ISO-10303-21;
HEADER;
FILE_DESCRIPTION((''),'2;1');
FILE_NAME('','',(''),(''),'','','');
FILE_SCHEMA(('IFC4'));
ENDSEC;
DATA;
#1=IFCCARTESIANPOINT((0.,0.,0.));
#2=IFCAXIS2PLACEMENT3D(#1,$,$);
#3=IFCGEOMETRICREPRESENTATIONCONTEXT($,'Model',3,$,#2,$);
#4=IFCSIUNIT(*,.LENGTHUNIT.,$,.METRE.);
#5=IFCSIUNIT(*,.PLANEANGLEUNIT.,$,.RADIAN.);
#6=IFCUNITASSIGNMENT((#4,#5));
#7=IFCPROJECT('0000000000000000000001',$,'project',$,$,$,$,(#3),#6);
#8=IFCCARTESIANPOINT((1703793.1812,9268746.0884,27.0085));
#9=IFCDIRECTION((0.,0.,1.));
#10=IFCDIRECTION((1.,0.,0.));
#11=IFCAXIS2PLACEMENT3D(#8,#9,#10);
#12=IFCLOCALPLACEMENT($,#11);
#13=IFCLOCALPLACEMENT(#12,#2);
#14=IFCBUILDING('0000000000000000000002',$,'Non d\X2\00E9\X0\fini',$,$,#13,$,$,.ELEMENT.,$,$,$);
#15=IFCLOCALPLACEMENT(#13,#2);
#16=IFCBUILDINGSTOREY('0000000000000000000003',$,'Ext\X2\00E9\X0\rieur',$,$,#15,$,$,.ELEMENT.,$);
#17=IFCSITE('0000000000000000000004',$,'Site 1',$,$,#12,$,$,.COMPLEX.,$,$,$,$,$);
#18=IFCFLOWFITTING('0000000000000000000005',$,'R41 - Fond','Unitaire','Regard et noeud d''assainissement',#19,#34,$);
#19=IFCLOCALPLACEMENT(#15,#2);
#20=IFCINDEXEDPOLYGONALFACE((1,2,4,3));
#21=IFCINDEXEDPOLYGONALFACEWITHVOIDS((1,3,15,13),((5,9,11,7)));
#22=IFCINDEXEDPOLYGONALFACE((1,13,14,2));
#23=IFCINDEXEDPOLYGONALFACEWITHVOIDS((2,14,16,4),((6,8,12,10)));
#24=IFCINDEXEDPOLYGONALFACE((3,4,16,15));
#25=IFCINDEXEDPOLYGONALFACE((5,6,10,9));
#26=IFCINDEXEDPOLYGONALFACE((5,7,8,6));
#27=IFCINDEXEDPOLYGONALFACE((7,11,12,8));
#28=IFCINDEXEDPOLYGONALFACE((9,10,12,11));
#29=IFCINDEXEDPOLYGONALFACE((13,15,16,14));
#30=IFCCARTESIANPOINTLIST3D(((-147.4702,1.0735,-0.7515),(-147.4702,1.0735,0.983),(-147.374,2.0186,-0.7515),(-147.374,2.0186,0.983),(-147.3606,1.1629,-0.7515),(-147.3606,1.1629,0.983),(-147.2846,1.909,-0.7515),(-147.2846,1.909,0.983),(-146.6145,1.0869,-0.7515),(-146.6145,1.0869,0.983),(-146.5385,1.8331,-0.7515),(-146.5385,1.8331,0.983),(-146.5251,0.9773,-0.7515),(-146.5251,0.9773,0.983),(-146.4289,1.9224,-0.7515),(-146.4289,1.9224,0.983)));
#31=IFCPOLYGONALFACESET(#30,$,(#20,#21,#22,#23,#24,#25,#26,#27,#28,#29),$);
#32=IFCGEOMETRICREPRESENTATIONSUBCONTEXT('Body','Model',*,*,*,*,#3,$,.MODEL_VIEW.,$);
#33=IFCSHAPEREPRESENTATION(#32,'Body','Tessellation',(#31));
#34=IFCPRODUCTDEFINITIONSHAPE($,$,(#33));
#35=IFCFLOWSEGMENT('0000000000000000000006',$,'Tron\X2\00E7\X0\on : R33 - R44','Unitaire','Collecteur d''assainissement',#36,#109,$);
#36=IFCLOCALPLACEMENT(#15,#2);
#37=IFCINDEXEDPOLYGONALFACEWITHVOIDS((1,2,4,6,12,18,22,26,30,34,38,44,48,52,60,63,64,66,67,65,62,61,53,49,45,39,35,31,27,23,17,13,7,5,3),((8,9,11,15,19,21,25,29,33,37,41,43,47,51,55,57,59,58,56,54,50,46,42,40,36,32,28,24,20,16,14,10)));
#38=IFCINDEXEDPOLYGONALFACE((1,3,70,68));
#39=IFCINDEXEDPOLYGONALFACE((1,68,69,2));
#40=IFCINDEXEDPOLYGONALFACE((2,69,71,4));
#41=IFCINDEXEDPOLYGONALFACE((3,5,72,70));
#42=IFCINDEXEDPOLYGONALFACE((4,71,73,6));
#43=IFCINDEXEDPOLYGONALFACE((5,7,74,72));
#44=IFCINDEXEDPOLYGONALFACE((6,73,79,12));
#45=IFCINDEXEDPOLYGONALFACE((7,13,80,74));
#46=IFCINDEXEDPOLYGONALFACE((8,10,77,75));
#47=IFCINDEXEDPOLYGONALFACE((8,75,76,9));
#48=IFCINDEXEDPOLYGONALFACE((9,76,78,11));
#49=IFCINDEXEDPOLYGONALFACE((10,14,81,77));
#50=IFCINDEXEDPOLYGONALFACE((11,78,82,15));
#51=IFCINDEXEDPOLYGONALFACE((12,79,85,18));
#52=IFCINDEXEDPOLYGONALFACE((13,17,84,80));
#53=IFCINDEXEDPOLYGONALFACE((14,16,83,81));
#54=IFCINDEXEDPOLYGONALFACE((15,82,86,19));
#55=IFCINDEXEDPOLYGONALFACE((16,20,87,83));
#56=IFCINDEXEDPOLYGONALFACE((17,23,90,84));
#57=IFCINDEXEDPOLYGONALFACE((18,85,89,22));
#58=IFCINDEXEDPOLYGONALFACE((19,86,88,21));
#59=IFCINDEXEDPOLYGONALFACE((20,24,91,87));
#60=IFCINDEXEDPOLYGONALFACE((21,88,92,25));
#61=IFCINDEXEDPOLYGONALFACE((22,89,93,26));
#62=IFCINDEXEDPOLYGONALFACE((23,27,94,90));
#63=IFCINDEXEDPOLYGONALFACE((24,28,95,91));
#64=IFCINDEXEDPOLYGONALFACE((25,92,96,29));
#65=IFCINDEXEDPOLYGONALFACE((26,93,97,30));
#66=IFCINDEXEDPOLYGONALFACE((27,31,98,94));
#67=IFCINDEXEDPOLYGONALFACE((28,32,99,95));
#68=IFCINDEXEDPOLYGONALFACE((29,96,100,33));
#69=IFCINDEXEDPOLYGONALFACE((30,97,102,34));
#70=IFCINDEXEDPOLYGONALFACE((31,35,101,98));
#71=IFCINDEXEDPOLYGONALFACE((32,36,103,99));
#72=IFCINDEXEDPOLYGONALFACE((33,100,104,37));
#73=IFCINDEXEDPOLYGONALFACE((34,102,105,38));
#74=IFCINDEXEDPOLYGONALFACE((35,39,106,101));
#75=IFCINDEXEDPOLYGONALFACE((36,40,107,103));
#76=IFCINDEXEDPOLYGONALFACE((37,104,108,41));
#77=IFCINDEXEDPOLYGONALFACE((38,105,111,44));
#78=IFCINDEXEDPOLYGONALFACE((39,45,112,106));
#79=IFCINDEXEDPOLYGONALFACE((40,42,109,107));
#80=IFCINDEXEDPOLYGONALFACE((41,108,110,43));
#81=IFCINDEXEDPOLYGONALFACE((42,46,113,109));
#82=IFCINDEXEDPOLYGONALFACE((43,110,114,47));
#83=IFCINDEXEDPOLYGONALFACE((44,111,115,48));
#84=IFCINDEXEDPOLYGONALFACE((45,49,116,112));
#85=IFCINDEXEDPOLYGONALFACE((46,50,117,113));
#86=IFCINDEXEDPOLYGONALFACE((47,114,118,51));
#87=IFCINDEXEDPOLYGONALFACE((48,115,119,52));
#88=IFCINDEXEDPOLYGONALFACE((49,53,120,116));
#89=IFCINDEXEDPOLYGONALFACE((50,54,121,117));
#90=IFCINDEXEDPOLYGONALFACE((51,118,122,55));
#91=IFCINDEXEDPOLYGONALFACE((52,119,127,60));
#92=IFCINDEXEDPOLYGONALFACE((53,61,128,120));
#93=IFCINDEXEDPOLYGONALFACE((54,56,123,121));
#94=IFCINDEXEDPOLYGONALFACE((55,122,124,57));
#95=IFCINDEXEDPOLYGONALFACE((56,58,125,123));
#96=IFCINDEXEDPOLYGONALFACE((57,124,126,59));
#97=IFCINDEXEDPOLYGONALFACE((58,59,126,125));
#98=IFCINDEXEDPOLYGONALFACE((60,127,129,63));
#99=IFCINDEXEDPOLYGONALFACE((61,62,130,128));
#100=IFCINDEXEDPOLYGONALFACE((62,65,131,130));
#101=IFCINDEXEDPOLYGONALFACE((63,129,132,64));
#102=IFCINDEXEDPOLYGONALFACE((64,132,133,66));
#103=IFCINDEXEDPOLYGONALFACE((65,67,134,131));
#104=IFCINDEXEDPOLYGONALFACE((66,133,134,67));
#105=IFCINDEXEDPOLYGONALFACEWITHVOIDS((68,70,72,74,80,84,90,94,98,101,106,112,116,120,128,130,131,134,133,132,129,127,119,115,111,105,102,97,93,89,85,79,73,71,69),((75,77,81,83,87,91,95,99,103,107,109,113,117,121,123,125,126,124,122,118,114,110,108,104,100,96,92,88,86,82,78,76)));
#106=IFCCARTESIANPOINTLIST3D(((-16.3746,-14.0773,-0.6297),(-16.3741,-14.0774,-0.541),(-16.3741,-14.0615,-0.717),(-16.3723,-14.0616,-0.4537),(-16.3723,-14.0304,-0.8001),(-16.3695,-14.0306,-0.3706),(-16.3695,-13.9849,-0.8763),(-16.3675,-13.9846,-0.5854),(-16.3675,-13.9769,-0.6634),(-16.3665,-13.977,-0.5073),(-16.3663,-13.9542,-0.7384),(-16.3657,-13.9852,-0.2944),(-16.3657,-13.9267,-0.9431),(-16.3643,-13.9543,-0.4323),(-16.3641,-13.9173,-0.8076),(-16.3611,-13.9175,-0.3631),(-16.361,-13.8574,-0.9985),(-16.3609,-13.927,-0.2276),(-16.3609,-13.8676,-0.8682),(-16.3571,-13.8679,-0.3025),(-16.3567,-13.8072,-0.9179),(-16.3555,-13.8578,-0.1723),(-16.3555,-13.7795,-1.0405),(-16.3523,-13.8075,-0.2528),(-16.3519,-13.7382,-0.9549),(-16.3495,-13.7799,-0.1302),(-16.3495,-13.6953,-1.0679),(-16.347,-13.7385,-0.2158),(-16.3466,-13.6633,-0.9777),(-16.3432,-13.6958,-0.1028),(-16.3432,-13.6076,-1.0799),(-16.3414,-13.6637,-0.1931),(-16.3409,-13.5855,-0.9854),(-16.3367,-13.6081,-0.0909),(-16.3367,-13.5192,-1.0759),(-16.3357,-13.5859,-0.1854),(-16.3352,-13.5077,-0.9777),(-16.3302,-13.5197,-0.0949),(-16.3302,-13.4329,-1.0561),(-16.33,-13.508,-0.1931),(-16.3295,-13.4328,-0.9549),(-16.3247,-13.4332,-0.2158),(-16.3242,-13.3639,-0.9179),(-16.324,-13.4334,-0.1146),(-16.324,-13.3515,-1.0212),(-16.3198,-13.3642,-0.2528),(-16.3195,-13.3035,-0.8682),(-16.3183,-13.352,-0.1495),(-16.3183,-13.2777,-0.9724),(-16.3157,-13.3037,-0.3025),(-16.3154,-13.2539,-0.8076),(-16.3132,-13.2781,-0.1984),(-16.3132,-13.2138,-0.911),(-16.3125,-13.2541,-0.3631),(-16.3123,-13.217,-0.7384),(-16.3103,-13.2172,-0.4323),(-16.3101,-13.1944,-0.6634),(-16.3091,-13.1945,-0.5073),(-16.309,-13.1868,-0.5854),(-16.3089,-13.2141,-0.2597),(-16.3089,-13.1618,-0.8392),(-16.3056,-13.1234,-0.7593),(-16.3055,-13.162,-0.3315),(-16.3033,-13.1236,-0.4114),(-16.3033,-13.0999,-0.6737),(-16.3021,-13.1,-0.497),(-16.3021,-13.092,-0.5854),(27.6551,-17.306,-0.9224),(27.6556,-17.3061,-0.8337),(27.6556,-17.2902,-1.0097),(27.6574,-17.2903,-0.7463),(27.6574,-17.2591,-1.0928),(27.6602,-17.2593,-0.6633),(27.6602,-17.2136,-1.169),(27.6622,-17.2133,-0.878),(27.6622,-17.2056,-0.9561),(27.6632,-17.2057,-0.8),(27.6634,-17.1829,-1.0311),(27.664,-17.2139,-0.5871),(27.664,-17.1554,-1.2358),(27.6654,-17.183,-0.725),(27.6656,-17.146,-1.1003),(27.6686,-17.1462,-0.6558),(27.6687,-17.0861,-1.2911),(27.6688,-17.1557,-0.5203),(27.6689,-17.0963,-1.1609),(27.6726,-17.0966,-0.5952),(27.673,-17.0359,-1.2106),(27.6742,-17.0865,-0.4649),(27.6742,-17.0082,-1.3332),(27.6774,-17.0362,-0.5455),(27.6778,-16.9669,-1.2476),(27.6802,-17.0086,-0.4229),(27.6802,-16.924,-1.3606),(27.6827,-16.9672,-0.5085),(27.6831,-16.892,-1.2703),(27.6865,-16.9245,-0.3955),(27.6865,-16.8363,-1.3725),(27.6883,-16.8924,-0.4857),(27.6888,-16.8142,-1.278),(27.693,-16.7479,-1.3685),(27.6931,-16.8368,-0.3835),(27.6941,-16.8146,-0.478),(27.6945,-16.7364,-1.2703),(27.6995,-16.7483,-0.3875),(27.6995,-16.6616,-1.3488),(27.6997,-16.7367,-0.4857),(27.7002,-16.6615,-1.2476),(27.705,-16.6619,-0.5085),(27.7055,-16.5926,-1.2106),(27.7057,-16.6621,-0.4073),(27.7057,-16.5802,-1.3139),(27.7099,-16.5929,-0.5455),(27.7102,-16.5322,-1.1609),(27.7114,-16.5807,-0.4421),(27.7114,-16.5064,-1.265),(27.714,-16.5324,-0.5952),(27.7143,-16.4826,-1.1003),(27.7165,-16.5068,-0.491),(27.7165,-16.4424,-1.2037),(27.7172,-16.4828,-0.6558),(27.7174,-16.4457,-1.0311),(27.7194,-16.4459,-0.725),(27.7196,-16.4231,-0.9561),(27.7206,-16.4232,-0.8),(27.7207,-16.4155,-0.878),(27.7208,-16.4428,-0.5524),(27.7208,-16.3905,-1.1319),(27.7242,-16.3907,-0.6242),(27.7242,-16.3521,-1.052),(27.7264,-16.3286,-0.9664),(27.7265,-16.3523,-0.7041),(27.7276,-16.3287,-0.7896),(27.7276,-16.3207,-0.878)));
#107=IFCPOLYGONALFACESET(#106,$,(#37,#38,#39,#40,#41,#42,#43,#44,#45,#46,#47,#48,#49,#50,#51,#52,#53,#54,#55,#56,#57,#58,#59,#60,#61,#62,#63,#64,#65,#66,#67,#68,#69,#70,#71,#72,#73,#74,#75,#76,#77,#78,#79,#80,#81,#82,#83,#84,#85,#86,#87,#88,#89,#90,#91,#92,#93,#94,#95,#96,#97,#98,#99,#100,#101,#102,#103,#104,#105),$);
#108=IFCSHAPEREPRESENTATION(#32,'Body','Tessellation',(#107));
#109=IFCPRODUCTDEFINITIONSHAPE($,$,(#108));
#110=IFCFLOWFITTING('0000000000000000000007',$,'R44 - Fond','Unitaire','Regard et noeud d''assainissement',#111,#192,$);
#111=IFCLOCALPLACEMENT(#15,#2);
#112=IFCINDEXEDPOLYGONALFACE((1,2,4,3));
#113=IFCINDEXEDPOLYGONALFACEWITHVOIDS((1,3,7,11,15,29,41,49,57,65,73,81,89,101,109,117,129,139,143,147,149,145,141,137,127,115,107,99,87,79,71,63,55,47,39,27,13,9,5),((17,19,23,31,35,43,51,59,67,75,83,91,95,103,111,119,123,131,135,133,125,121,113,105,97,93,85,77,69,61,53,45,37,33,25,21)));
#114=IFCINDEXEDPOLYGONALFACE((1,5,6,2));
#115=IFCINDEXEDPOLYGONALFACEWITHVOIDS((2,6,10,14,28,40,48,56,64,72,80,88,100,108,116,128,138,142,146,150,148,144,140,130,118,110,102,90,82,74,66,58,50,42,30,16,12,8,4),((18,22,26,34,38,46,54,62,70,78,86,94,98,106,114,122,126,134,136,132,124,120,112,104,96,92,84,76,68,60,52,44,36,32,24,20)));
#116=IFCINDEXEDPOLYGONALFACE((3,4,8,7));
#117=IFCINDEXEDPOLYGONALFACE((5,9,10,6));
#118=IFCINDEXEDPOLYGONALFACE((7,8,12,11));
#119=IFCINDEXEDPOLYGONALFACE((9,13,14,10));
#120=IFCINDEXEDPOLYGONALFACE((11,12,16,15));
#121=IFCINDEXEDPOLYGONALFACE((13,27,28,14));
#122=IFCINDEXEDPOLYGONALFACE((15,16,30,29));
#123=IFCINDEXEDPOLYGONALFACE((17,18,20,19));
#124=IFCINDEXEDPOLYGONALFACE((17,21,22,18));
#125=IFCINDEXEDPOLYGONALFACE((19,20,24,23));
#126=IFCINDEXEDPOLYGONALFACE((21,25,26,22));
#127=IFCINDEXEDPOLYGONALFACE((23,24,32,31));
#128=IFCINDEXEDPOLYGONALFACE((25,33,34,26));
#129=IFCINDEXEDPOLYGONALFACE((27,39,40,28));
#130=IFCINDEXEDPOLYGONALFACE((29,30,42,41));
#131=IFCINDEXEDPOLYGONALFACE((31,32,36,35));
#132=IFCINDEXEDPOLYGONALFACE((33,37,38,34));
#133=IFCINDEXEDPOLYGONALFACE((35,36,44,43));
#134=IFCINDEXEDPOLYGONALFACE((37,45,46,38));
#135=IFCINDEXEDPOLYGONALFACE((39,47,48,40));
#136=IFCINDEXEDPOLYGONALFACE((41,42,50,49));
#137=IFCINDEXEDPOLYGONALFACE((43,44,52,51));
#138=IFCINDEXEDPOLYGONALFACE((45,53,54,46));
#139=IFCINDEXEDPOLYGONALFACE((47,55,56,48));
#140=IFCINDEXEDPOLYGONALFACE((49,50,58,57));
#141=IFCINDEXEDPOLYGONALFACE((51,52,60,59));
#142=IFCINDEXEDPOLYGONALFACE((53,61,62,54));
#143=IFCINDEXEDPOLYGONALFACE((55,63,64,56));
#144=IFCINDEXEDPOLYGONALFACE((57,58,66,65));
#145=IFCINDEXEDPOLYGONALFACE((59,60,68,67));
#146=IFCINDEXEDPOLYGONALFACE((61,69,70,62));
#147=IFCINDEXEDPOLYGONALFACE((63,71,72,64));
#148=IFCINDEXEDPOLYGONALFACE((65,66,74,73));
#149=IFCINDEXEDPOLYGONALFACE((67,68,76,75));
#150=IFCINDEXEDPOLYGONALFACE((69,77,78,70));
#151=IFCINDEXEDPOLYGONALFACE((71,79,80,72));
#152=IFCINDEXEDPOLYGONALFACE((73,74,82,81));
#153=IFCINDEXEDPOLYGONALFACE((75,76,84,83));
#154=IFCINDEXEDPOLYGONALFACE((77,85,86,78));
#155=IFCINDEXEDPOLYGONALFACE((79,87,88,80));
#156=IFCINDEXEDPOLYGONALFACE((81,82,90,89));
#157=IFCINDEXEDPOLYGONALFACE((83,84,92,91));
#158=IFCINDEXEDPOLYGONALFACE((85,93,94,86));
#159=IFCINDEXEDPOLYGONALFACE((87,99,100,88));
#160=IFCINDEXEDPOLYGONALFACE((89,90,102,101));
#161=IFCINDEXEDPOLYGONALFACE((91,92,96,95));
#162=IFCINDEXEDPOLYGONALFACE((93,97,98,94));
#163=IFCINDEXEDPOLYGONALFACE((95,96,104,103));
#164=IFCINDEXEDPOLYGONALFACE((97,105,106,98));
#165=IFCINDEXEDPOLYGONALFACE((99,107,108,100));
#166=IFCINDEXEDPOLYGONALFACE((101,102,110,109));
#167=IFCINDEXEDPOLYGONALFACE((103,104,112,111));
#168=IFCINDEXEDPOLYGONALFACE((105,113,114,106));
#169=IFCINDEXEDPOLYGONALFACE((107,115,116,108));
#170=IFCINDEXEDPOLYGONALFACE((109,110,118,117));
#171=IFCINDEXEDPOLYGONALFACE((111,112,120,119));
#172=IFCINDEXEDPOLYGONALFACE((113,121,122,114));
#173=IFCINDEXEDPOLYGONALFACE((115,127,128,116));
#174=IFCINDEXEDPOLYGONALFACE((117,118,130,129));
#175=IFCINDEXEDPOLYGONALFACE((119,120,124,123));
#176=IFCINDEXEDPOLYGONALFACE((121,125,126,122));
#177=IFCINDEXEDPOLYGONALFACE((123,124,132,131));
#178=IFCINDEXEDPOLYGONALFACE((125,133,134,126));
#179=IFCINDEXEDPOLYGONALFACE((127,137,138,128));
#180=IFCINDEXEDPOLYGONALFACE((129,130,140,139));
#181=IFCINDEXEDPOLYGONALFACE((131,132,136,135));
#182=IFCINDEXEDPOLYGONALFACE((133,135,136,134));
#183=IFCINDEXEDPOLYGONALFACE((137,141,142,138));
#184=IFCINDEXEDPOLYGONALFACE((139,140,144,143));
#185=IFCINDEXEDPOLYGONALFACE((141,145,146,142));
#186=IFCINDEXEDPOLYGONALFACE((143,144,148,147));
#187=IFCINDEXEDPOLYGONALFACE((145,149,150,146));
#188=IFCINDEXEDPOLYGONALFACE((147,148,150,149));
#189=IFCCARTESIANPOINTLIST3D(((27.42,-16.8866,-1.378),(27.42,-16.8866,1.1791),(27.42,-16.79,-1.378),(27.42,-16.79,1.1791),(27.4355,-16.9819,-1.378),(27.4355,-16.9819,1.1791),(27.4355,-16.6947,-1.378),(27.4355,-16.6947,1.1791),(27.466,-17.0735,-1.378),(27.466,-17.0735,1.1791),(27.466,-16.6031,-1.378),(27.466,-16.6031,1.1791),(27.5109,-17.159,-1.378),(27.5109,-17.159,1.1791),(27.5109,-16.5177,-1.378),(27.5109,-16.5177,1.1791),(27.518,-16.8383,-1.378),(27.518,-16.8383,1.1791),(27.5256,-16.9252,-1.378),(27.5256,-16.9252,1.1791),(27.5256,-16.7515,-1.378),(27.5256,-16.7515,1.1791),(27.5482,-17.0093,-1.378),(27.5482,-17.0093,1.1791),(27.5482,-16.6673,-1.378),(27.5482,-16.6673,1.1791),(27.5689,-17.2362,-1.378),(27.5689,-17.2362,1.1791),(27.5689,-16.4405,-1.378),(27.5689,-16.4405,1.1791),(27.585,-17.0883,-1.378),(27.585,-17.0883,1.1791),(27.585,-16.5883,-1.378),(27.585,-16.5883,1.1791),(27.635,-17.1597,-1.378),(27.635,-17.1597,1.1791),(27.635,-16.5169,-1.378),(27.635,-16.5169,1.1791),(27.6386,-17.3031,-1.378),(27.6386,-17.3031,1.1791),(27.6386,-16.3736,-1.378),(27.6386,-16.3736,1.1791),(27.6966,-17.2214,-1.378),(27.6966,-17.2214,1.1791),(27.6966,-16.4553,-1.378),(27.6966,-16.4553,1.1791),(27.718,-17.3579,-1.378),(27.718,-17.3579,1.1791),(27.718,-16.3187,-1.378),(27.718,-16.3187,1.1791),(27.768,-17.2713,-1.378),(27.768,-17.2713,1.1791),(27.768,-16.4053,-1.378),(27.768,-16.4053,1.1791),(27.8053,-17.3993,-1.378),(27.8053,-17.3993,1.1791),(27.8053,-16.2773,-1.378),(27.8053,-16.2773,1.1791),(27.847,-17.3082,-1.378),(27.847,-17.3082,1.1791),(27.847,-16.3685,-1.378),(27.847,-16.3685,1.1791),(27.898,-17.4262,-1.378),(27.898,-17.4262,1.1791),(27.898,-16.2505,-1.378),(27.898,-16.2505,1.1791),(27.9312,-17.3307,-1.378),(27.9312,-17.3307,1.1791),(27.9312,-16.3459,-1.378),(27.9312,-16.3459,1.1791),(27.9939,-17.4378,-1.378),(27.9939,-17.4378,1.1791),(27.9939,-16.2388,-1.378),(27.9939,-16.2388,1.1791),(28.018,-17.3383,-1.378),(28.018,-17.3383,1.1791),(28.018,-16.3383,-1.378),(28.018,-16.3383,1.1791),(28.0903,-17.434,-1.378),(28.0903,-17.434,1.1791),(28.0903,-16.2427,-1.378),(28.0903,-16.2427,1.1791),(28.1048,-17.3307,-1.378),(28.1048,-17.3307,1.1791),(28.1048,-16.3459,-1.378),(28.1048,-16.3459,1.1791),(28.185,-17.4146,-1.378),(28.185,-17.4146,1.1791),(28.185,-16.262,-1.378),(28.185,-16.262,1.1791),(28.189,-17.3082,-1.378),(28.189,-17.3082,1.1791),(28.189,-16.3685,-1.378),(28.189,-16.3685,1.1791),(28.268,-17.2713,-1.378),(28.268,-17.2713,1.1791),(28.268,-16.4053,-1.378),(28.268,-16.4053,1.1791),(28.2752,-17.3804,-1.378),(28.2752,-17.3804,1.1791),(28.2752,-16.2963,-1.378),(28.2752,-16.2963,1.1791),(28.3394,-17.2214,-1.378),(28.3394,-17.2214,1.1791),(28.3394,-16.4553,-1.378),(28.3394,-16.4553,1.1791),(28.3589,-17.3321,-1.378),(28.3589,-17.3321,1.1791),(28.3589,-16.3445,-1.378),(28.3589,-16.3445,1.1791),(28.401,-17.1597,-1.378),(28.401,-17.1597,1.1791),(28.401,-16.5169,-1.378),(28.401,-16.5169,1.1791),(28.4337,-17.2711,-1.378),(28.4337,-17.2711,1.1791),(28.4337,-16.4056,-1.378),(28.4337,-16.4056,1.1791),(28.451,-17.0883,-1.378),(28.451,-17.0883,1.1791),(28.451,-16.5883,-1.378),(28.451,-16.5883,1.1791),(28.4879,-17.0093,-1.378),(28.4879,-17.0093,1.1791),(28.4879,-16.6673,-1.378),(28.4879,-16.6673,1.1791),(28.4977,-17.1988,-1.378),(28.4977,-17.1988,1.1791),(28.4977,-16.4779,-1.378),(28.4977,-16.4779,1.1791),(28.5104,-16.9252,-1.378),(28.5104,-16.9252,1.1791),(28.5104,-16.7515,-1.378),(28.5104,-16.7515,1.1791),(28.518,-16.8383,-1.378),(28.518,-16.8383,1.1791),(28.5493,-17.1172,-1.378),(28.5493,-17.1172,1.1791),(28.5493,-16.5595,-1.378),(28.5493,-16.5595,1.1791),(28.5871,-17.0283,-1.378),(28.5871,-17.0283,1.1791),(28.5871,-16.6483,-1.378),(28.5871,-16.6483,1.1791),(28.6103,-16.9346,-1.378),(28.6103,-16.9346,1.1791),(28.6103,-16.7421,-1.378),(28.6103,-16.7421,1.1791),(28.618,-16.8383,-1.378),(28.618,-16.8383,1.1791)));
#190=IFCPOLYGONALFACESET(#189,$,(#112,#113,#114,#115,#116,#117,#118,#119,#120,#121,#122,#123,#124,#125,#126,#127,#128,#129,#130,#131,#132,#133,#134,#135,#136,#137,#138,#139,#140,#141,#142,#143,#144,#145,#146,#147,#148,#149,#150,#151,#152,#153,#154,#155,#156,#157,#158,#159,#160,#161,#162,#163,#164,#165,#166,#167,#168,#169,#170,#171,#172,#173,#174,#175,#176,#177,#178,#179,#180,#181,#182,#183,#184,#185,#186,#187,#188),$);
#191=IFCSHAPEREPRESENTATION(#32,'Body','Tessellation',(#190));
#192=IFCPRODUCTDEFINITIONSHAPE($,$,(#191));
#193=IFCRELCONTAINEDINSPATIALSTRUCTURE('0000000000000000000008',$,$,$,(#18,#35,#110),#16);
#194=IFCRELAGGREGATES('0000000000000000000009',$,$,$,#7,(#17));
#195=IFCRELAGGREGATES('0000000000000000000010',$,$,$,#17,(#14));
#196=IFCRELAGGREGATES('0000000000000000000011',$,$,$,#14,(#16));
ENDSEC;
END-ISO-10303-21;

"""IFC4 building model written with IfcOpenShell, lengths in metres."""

from ifc_helpers import new_model, si_unit, frame, origin, origin_2d, place, context, subcontext, project, spatial, hollow_rectangle, hollow_circle, extrude, element, save


model = new_model("IFC4")

# Units and contexts
model_context = context("Model", 3, world=origin())
body_context = subcontext(model_context, "Body", "Model", "MODEL_VIEW")
ifc_project = project(units=[si_unit("LENGTHUNIT", "METRE"), si_unit("PLANEANGLEUNIT", "RADIAN")], contexts=[model_context])

# Site, building, storey
site_placement = place(None, frame((1703793.1812, 9268746.0884, 27.0085), z_axis=(0.0, 0.0, 1.0), x_axis=(1.0, 0.0, 0.0)))
site = spatial("IfcSite", under=ifc_project, at=site_placement, Name="Site 1", CompositionType="COMPLEX")
building_placement = place(site_placement, origin())
building = spatial("IfcBuilding", under=site, at=building_placement, Name="Non défini", CompositionType="ELEMENT")
storey_placement = place(building_placement, origin())
storey = spatial("IfcBuildingStorey", under=building, at=storey_placement, Name="Extérieur", CompositionType="ELEMENT")

# Flow fitting
flow_fitting_1_placement = place(storey_placement, origin())
element("IfcFlowFitting", 1, at=flow_fitting_1_placement, inside=storey, Name="R41 - Fond", Description="Unitaire", ObjectType="Regard et noeud d'assainissement", context=body_context, shape_type="SweptSolid", body=[
    extrude(hollow_rectangle(XDim=0.95, YDim=0.95, WallThickness=0.1, at=origin_2d()), frame((-146.9495, 1.498, -0.7515), z_axis=(0.0, 0.0, 1.0), x_axis=(0.101267, 0.994859, 0.0)), (0.0, 0.0, 1.0), 1.7345),
])

# Flow segment
flow_segment_1_placement = place(storey_placement, origin())
element("IfcFlowSegment", 2, at=flow_segment_1_placement, inside=storey, Name="Tronçon : R33 - R44", Description="Unitaire", ObjectType="Collecteur d'assainissement", context=body_context, shape_type="SweptSolid", body=[
    extrude(hollow_circle(Radius=0.495, WallThickness=0.095, at=origin_2d()), frame((-16.3383, -13.5857, -0.5854), z_axis=(0.9973, -0.073132, -0.006629), x_axis=(0.073134, 0.997322, 0.0)), (0.0, 0.0, 1.0), 44.1489),
])

# Flow fitting
flow_fitting_2_placement = place(storey_placement, origin())
element("IfcFlowFitting", 3, at=flow_fitting_2_placement, inside=storey, Name="R44 - Fond", Description="Unitaire", ObjectType="Regard et noeud d'assainissement", context=body_context, shape_type="SweptSolid", body=[
    extrude(hollow_circle(Radius=0.6, WallThickness=0.1, at=origin_2d()), frame((28.018, -16.8383, -1.378), z_axis=(0.0, 0.0, 1.0), x_axis=(1.0, 0.0, 0.0)), (0.0, 0.0, 1.0), 2.5572),
])

save(model, "model.ifc")
